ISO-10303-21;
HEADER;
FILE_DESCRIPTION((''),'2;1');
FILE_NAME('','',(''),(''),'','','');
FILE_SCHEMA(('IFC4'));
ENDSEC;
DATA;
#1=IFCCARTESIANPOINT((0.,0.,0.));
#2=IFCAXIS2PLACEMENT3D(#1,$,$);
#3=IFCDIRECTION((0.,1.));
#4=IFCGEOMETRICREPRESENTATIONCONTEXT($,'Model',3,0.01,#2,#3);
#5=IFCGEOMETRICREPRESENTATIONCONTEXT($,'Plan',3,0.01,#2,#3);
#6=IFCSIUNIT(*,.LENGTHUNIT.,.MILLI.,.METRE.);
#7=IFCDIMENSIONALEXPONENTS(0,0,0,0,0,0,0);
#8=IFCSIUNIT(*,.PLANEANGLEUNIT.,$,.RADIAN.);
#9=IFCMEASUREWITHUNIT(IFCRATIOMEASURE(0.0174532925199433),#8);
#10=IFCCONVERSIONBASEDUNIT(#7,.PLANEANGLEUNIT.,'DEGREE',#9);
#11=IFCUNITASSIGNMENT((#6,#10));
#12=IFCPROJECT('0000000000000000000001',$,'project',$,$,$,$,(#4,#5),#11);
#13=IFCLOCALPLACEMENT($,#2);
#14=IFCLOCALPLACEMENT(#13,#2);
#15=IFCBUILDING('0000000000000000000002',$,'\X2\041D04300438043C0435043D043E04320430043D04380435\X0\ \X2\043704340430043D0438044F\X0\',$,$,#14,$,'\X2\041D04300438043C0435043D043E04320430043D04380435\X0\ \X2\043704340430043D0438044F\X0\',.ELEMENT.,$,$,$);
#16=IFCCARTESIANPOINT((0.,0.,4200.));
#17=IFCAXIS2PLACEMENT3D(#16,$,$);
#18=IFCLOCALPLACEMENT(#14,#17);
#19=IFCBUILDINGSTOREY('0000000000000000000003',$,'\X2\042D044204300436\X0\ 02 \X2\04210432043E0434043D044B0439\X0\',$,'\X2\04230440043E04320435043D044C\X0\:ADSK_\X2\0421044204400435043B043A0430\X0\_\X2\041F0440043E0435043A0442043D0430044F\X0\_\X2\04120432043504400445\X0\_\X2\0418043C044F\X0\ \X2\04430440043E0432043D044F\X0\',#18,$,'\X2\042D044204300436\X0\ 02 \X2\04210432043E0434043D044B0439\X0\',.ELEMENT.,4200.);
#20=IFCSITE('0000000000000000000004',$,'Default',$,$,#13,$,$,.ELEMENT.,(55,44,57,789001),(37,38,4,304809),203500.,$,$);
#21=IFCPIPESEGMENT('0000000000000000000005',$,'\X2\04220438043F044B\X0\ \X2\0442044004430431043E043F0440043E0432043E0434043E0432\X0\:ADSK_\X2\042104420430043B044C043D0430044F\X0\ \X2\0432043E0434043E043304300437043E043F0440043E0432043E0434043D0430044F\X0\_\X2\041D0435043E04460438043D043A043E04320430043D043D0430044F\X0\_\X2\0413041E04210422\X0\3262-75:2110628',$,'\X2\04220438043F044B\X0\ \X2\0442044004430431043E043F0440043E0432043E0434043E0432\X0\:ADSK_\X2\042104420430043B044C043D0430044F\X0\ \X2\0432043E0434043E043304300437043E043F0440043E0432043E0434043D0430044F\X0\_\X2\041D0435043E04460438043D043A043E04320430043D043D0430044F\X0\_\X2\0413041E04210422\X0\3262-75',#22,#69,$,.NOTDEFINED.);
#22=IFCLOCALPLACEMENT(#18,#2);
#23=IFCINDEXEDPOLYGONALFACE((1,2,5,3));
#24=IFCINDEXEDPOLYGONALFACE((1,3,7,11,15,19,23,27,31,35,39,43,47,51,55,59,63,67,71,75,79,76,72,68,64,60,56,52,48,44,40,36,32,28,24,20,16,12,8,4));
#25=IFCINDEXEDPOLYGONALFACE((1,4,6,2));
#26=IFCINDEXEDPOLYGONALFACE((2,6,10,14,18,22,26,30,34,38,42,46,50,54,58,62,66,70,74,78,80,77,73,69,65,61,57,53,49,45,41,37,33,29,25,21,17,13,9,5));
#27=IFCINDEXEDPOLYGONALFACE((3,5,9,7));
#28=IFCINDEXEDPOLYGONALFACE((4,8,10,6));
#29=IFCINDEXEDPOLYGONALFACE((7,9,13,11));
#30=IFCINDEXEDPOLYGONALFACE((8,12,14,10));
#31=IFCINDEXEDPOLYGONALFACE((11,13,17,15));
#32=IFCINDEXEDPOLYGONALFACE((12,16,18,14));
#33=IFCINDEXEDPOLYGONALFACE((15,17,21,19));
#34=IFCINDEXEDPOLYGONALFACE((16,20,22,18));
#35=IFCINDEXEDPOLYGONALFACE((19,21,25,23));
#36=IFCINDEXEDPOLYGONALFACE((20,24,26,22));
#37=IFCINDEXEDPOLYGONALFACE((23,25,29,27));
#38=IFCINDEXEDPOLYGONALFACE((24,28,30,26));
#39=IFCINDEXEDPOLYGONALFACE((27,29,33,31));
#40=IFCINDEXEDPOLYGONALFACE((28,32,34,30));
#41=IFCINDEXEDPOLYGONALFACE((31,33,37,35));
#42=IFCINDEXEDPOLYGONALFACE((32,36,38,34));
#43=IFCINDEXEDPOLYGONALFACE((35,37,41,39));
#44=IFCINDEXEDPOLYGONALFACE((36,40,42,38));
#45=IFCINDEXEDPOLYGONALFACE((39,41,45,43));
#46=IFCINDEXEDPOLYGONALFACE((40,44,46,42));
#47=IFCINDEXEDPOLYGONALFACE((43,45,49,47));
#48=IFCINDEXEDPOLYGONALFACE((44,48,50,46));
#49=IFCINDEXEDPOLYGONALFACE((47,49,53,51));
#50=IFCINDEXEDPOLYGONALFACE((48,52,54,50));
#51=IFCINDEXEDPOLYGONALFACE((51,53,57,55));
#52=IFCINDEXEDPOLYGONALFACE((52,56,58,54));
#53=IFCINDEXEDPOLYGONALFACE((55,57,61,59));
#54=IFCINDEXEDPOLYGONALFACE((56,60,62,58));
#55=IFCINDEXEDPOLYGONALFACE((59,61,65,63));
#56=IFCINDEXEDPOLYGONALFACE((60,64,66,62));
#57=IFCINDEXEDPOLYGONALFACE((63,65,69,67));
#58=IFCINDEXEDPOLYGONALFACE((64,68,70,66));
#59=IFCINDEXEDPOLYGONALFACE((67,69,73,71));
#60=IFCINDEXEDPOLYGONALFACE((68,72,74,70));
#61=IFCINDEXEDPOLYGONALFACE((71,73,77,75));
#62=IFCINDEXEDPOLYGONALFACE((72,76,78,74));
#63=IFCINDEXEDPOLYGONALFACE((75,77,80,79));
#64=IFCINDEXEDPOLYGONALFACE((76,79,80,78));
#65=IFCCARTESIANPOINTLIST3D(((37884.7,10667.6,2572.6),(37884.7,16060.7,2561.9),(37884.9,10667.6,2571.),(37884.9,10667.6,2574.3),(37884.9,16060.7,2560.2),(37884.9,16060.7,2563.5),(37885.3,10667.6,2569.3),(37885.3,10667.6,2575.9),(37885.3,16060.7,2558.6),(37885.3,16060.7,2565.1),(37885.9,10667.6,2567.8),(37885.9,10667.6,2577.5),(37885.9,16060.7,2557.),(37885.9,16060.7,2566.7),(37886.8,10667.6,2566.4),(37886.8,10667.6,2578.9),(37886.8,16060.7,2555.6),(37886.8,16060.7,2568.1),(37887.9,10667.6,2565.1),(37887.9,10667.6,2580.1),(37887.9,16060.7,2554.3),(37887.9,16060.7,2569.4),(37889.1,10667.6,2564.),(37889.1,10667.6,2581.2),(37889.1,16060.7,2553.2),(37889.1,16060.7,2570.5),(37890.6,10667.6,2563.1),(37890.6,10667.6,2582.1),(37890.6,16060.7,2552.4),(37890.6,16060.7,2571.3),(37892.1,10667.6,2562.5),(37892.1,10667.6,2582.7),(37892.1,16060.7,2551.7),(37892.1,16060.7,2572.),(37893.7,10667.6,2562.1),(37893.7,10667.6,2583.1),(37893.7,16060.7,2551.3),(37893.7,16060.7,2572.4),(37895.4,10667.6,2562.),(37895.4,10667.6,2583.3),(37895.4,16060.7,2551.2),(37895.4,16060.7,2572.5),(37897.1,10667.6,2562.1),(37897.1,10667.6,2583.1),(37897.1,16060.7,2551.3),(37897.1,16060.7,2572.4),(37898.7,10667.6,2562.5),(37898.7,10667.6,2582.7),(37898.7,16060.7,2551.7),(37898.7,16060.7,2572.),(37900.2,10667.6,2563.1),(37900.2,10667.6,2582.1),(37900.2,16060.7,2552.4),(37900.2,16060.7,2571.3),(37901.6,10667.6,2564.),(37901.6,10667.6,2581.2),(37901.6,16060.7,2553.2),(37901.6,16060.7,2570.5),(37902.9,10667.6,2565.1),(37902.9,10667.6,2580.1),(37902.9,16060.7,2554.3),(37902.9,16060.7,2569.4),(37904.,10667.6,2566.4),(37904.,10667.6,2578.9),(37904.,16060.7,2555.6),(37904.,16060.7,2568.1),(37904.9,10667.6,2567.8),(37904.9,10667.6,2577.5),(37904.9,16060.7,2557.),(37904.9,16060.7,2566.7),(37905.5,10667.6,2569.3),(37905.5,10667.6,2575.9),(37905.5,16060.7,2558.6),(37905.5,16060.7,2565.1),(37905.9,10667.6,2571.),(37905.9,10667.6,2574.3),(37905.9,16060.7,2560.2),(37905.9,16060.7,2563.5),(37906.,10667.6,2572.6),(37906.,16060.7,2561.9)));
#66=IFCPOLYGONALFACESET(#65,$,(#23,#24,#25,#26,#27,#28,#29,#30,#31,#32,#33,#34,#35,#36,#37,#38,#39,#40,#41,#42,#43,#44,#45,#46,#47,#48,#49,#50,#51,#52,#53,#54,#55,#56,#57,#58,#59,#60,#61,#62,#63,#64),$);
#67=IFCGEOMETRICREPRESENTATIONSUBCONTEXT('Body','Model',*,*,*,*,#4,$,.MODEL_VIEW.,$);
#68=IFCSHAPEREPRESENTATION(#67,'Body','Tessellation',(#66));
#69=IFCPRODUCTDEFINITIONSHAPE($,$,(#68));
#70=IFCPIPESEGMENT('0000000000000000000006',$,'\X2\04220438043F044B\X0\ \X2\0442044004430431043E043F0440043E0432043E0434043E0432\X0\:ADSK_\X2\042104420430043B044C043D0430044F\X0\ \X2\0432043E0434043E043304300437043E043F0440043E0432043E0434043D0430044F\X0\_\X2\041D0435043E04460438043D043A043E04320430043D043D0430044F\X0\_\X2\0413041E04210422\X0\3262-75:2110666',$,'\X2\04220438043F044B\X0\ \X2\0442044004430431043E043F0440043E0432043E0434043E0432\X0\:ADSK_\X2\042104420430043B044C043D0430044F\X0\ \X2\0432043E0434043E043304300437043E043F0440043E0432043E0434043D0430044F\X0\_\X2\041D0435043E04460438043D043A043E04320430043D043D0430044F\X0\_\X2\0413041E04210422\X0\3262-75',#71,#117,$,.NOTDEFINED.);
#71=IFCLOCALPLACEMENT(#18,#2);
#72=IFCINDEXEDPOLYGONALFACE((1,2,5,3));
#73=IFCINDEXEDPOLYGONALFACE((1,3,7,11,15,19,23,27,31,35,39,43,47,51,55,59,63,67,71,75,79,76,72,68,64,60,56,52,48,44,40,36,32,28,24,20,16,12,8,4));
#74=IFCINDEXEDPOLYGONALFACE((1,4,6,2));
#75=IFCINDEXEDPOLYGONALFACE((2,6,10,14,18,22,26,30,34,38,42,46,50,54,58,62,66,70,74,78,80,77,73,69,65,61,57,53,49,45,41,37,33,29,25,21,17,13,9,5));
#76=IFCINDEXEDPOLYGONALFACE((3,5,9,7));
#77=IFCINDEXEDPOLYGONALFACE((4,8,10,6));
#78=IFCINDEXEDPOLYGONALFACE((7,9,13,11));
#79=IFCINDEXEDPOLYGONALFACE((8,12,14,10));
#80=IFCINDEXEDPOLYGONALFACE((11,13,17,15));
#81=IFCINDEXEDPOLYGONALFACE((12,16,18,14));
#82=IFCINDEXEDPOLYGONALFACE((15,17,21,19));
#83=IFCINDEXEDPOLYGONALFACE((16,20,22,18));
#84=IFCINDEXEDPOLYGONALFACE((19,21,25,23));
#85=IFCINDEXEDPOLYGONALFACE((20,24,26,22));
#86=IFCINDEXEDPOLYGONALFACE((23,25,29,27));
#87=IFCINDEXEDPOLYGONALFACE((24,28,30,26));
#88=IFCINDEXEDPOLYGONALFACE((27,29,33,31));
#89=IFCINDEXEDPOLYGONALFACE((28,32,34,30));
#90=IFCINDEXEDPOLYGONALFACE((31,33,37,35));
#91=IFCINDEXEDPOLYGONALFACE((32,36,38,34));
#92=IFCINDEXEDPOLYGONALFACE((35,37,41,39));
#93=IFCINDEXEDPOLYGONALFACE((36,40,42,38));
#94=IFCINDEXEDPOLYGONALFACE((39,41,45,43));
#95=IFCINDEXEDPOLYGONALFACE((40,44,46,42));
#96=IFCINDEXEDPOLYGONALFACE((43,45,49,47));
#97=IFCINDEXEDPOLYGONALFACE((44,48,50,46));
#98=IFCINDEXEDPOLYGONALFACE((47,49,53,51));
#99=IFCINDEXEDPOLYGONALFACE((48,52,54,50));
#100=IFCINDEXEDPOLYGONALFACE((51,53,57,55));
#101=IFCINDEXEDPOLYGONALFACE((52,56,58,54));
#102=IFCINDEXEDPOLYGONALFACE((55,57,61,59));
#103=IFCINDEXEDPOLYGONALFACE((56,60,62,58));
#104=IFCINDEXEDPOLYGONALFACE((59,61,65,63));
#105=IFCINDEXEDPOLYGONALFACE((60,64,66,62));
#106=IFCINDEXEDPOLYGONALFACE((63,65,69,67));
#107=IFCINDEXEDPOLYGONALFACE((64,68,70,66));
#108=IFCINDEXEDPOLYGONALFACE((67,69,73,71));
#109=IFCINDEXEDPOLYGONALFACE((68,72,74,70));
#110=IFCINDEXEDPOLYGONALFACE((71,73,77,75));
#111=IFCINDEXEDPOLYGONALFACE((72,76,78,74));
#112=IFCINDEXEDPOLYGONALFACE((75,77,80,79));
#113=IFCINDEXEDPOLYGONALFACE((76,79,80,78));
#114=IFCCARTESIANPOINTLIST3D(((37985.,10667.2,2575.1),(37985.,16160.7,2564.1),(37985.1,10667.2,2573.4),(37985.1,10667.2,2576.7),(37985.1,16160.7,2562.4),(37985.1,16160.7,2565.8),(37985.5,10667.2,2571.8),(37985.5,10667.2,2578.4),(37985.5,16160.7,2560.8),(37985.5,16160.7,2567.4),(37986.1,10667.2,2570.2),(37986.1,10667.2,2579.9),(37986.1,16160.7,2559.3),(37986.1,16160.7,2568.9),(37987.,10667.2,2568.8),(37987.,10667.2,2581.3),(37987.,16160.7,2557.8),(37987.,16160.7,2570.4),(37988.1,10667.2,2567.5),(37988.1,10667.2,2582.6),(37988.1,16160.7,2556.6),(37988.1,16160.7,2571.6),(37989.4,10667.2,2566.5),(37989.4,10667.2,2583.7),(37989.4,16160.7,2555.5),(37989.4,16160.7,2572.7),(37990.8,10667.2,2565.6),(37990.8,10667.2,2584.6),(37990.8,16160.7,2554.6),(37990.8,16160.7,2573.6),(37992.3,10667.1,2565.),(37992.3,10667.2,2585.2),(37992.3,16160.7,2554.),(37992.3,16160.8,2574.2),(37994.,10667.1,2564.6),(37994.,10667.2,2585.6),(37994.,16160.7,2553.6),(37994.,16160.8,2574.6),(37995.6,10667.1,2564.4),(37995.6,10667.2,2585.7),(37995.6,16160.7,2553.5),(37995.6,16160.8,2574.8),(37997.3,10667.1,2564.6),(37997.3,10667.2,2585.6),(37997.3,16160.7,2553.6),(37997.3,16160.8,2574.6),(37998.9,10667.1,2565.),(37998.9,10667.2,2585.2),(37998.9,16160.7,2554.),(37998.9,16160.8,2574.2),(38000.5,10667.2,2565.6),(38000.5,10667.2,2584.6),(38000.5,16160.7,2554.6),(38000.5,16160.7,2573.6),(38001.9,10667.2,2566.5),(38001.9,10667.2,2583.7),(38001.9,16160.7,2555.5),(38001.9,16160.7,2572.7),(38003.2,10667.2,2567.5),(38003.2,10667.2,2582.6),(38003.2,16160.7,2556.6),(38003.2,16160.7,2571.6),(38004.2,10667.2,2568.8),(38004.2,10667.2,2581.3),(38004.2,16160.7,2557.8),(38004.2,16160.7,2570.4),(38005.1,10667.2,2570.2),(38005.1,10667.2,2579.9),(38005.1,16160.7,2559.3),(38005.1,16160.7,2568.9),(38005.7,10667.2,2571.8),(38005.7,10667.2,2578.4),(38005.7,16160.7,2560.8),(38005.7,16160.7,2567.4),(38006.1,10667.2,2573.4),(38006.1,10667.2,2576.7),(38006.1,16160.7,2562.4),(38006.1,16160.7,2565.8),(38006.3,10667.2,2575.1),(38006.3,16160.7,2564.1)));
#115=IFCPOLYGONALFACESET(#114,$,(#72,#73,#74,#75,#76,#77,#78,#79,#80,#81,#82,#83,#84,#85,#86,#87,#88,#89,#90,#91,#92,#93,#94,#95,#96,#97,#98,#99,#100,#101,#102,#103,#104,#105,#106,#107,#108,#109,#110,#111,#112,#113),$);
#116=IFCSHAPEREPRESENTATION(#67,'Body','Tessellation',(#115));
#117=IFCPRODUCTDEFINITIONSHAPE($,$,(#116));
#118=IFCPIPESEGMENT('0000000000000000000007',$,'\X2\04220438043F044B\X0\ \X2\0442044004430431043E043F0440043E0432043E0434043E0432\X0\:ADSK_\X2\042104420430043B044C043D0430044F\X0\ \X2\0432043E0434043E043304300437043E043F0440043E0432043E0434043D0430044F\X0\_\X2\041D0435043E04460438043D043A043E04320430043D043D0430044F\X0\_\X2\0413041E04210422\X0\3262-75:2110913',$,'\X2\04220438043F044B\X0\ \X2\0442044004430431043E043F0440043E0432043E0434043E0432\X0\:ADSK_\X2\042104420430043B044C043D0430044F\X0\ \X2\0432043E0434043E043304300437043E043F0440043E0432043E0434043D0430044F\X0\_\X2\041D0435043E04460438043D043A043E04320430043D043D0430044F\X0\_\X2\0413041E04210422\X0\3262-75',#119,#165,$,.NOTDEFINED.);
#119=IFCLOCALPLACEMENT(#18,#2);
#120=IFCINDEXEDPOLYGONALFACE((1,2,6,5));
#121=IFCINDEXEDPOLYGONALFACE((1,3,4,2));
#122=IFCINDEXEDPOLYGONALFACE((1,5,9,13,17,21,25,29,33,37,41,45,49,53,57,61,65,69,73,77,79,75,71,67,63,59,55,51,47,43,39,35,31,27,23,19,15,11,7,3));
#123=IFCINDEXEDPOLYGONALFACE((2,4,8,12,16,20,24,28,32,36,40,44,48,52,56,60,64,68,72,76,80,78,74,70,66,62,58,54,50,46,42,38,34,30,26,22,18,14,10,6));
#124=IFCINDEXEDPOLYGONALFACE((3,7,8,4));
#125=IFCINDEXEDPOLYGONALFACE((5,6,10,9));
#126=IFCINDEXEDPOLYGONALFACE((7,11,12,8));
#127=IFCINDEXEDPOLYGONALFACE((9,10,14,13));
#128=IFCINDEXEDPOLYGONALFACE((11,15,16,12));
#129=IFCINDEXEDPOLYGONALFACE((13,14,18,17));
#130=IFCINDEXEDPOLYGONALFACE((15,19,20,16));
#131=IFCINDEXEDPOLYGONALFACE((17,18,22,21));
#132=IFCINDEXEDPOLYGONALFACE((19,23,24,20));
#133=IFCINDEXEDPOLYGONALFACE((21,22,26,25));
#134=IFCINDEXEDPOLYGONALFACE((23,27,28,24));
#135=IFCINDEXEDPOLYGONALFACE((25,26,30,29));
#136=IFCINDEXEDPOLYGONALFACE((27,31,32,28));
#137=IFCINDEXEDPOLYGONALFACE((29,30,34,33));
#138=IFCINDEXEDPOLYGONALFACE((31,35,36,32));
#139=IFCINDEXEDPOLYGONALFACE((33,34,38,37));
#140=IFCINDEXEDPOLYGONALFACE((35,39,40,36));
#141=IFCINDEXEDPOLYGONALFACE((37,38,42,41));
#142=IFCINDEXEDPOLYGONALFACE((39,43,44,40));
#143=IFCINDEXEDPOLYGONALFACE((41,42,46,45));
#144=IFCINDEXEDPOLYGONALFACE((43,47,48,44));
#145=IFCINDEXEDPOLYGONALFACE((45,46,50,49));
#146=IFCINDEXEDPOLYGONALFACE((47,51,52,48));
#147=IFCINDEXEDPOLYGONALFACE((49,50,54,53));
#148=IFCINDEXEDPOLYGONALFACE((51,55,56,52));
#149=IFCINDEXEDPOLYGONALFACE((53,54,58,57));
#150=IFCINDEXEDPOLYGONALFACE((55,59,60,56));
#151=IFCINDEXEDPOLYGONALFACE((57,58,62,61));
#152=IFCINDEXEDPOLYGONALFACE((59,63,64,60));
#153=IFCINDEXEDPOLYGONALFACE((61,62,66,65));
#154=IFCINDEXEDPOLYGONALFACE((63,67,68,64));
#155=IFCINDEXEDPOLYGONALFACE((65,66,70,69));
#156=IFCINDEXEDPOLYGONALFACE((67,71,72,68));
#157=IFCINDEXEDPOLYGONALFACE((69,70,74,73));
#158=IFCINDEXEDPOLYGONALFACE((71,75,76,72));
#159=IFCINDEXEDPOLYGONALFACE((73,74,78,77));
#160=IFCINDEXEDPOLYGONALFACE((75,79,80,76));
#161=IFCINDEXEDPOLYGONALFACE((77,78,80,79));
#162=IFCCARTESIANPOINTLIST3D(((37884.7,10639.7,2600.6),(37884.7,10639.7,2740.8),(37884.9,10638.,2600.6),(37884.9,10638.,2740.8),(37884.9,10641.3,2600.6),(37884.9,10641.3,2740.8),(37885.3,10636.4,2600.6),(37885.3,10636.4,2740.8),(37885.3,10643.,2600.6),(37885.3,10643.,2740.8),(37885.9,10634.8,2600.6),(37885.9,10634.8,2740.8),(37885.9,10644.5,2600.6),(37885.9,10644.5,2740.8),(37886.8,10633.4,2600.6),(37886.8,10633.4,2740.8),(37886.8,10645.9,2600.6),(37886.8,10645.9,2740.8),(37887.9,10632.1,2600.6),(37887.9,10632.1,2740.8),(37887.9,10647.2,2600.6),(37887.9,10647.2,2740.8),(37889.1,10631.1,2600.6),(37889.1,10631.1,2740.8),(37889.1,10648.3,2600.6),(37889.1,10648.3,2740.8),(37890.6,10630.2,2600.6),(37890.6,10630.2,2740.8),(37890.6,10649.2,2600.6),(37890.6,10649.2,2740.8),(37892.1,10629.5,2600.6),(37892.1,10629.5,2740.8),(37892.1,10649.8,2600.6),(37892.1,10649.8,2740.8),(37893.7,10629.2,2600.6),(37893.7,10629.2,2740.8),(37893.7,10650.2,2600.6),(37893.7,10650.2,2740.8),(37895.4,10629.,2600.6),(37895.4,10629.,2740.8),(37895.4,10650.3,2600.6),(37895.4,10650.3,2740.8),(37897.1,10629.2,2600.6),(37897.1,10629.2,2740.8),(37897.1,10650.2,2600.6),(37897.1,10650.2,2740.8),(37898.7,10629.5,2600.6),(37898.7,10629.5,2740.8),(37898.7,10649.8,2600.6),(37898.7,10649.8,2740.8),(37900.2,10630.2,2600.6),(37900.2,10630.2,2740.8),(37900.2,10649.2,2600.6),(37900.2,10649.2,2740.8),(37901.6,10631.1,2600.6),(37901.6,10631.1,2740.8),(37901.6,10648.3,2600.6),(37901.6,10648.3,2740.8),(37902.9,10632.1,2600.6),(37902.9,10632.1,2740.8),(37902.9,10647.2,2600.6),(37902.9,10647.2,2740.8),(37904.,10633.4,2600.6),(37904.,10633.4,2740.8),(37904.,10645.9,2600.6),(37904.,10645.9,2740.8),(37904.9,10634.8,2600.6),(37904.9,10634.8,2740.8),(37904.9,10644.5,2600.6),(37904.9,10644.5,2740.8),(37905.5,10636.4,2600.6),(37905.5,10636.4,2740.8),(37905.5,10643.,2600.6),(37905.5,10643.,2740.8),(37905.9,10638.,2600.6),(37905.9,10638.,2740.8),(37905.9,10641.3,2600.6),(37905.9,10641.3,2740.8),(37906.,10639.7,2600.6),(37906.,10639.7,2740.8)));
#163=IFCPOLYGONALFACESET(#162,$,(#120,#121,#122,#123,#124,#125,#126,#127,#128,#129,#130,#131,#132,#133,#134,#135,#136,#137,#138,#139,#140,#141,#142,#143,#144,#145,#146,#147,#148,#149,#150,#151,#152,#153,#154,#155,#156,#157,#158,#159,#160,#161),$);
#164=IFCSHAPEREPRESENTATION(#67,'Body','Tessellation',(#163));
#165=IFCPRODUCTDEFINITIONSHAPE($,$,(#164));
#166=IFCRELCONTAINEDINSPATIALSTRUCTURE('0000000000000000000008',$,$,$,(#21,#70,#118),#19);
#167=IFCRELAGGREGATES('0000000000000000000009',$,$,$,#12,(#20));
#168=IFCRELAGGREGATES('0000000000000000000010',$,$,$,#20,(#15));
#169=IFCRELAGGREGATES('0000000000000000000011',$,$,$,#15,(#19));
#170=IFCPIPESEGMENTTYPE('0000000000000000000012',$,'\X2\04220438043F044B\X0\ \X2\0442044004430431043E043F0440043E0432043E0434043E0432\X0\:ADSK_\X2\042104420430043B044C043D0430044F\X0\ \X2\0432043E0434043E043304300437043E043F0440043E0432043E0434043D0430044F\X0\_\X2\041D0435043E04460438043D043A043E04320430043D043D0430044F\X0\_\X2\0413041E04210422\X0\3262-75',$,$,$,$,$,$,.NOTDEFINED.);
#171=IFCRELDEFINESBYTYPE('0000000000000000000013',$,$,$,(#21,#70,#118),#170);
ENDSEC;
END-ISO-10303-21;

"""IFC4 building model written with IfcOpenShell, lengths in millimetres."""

from ifc_helpers import new_model, entity, si_unit, converted_unit, direction, frame, origin, place, context, subcontext, project, spatial, indexed_curve, outline, extrude, type_object, element, save


model = new_model("IFC4")

# Units and contexts
model_context = context("Model", 3, precision=0.01, world=origin(), true_north=direction((0.0, 1.0)))
plan_context = context("Plan", 3, precision=0.01, world=origin(), true_north=direction((0.0, 1.0)))
body_context = subcontext(model_context, "Body", "Model", "MODEL_VIEW")
ifc_project = project(units=[si_unit("LENGTHUNIT", "METRE", prefix="MILLI"), converted_unit("PLANEANGLEUNIT", "DEGREE", entity("IfcRatioMeasure", 0.0174532925199433), si_unit("PLANEANGLEUNIT", "RADIAN"), dimensions=[0, 0, 0, 0, 0, 0, 0])], contexts=[model_context, plan_context])

# Site, building, storey
site_placement = place(None, origin())
site = spatial("IfcSite", under=ifc_project, at=site_placement, Name="Default", CompositionType="ELEMENT", RefLatitude=(55, 44, 57, 789001), RefLongitude=(37, 38, 4, 304809), RefElevation=203500.0)
building_placement = place(site_placement, origin())
building = spatial("IfcBuilding", under=site, at=building_placement, Name="Наименование здания", LongName="Наименование здания", CompositionType="ELEMENT")
storey_placement = place(building_placement, frame((0.0, 0.0, 4200.0)))
storey = spatial("IfcBuildingStorey", under=building, at=storey_placement, Name="Этаж 02 Сводный", ObjectType="Уровень:ADSK_Стрелка_Проектная_Вверх_Имя уровня", LongName="Этаж 02 Сводный", CompositionType="ELEMENT", Elevation=4200.0)

# Pipe segments
placement = place(storey_placement, origin())
pipe_segment_type_1 = type_object("IfcPipeSegmentType", Name="Типы трубопроводов:ADSK_Стальная водогазопроводная_Неоцинкованная_ГОСТ3262-75", PredefinedType="NOTDEFINED")
element("IfcPipeSegment", 1, at=placement, inside=storey, type_object=pipe_segment_type_1, Name="Типы трубопроводов:ADSK_Стальная водогазопроводная_Неоцинкованная_ГОСТ3262-75:2110628", ObjectType="Типы трубопроводов:ADSK_Стальная водогазопроводная_Неоцинкованная_ГОСТ3262-75", PredefinedType="NOTDEFINED", context=body_context, shape_type="SweptSolid", body=[
    extrude(outline(indexed_curve([(10.7, 0.0), (10.5, 1.7), (10.1, 3.3), (9.5, 4.8), (8.6, 6.3), (7.5, 7.5), (6.3, 8.6), (4.8, 9.5), (3.3, 10.1), (1.7, 10.5), (0.0, 10.6), (-1.7, 10.5), (-3.3, 10.1), (-4.8, 9.5), (-6.3, 8.6), (-7.5, 7.5), (-8.6, 6.3), (-9.5, 4.8), (-10.1, 3.3), (-10.5, 1.7), (-10.7, 0.0), (-10.5, -1.7), (-10.1, -3.3), (-9.5, -4.8), (-8.6, -6.3), (-7.5, -7.5), (-6.3, -8.6), (-4.8, -9.5), (-3.3, -10.1), (-1.7, -10.5), (0.0, -10.6), (1.7, -10.5), (3.3, -10.1), (4.8, -9.5), (6.3, -8.6), (7.5, -7.5), (8.6, -6.3), (9.5, -4.8), (10.1, -3.3), (10.5, -1.7), (10.7, 0.0)], self_intersect=False)), frame((37895.4, 16060.7, 2561.8), z_axis=(0.0, -0.999998, 0.001997), x_axis=(-1.0, 0.0, 0.0)), (0.0, 0.0, 1.0), 5393.1),
])
element("IfcPipeSegment", 2, at=placement, inside=storey, type_object=pipe_segment_type_1, Name="Типы трубопроводов:ADSK_Стальная водогазопроводная_Неоцинкованная_ГОСТ3262-75:2110666", ObjectType="Типы трубопроводов:ADSK_Стальная водогазопроводная_Неоцинкованная_ГОСТ3262-75", PredefinedType="NOTDEFINED", context=body_context, shape_type="SweptSolid", body=[
    extrude(outline(indexed_curve([(10.7, 0.0), (10.5, 1.7), (10.1, 3.3), (9.5, 4.8), (8.6, 6.3), (7.5, 7.5), (6.3, 8.6), (4.8, 9.5), (3.3, 10.1), (1.7, 10.5), (0.0, 10.7), (-1.7, 10.5), (-3.3, 10.1), (-4.8, 9.5), (-6.3, 8.6), (-7.5, 7.5), (-8.6, 6.3), (-9.5, 4.8), (-10.1, 3.3), (-10.5, 1.7), (-10.7, 0.0), (-10.5, -1.7), (-10.1, -3.3), (-9.5, -4.8), (-8.6, -6.3), (-7.5, -7.5), (-6.3, -8.6), (-4.8, -9.5), (-3.3, -10.1), (-1.7, -10.5), (0.0, -10.7), (1.7, -10.5), (3.3, -10.1), (4.8, -9.5), (6.3, -8.6), (7.5, -7.5), (8.6, -6.3), (9.5, -4.8), (10.1, -3.3), (10.5, -1.7), (10.7, 0.0)], self_intersect=False)), frame((37995.6, 10667.2, 2575.1), z_axis=(0.0, 0.999998, -0.001997), x_axis=(-1.0, 0.0, 0.0)), (0.0, 0.0, 1.0), 5493.6),
])
element("IfcPipeSegment", 3, at=placement, inside=storey, type_object=pipe_segment_type_1, Name="Типы трубопроводов:ADSK_Стальная водогазопроводная_Неоцинкованная_ГОСТ3262-75:2110913", ObjectType="Типы трубопроводов:ADSK_Стальная водогазопроводная_Неоцинкованная_ГОСТ3262-75", PredefinedType="NOTDEFINED", context=body_context, shape_type="SweptSolid", body=[
    extrude(outline(indexed_curve([(10.7, 0.0), (10.5, 1.7), (10.1, 3.3), (9.5, 4.8), (8.6, 6.3), (7.5, 7.5), (6.3, 8.6), (4.8, 9.5), (3.3, 10.1), (1.7, 10.5), (0.0, 10.7), (-1.7, 10.5), (-3.3, 10.1), (-4.8, 9.5), (-6.3, 8.6), (-7.5, 7.5), (-8.6, 6.3), (-9.5, 4.8), (-10.1, 3.3), (-10.5, 1.7), (-10.6, 0.0), (-10.5, -1.7), (-10.1, -3.3), (-9.5, -4.8), (-8.6, -6.3), (-7.5, -7.5), (-6.3, -8.6), (-4.8, -9.5), (-3.3, -10.1), (-1.7, -10.5), (0.0, -10.7), (1.7, -10.5), (3.3, -10.1), (4.8, -9.5), (6.3, -8.6), (7.5, -7.5), (8.6, -6.3), (9.5, -4.8), (10.1, -3.3), (10.5, -1.7), (10.7, 0.0)], self_intersect=False)), frame((37895.4, 10639.7, 2600.6)), (0.0, 0.0, 1.0), 140.2),
])

save(model, "model.ifc")
